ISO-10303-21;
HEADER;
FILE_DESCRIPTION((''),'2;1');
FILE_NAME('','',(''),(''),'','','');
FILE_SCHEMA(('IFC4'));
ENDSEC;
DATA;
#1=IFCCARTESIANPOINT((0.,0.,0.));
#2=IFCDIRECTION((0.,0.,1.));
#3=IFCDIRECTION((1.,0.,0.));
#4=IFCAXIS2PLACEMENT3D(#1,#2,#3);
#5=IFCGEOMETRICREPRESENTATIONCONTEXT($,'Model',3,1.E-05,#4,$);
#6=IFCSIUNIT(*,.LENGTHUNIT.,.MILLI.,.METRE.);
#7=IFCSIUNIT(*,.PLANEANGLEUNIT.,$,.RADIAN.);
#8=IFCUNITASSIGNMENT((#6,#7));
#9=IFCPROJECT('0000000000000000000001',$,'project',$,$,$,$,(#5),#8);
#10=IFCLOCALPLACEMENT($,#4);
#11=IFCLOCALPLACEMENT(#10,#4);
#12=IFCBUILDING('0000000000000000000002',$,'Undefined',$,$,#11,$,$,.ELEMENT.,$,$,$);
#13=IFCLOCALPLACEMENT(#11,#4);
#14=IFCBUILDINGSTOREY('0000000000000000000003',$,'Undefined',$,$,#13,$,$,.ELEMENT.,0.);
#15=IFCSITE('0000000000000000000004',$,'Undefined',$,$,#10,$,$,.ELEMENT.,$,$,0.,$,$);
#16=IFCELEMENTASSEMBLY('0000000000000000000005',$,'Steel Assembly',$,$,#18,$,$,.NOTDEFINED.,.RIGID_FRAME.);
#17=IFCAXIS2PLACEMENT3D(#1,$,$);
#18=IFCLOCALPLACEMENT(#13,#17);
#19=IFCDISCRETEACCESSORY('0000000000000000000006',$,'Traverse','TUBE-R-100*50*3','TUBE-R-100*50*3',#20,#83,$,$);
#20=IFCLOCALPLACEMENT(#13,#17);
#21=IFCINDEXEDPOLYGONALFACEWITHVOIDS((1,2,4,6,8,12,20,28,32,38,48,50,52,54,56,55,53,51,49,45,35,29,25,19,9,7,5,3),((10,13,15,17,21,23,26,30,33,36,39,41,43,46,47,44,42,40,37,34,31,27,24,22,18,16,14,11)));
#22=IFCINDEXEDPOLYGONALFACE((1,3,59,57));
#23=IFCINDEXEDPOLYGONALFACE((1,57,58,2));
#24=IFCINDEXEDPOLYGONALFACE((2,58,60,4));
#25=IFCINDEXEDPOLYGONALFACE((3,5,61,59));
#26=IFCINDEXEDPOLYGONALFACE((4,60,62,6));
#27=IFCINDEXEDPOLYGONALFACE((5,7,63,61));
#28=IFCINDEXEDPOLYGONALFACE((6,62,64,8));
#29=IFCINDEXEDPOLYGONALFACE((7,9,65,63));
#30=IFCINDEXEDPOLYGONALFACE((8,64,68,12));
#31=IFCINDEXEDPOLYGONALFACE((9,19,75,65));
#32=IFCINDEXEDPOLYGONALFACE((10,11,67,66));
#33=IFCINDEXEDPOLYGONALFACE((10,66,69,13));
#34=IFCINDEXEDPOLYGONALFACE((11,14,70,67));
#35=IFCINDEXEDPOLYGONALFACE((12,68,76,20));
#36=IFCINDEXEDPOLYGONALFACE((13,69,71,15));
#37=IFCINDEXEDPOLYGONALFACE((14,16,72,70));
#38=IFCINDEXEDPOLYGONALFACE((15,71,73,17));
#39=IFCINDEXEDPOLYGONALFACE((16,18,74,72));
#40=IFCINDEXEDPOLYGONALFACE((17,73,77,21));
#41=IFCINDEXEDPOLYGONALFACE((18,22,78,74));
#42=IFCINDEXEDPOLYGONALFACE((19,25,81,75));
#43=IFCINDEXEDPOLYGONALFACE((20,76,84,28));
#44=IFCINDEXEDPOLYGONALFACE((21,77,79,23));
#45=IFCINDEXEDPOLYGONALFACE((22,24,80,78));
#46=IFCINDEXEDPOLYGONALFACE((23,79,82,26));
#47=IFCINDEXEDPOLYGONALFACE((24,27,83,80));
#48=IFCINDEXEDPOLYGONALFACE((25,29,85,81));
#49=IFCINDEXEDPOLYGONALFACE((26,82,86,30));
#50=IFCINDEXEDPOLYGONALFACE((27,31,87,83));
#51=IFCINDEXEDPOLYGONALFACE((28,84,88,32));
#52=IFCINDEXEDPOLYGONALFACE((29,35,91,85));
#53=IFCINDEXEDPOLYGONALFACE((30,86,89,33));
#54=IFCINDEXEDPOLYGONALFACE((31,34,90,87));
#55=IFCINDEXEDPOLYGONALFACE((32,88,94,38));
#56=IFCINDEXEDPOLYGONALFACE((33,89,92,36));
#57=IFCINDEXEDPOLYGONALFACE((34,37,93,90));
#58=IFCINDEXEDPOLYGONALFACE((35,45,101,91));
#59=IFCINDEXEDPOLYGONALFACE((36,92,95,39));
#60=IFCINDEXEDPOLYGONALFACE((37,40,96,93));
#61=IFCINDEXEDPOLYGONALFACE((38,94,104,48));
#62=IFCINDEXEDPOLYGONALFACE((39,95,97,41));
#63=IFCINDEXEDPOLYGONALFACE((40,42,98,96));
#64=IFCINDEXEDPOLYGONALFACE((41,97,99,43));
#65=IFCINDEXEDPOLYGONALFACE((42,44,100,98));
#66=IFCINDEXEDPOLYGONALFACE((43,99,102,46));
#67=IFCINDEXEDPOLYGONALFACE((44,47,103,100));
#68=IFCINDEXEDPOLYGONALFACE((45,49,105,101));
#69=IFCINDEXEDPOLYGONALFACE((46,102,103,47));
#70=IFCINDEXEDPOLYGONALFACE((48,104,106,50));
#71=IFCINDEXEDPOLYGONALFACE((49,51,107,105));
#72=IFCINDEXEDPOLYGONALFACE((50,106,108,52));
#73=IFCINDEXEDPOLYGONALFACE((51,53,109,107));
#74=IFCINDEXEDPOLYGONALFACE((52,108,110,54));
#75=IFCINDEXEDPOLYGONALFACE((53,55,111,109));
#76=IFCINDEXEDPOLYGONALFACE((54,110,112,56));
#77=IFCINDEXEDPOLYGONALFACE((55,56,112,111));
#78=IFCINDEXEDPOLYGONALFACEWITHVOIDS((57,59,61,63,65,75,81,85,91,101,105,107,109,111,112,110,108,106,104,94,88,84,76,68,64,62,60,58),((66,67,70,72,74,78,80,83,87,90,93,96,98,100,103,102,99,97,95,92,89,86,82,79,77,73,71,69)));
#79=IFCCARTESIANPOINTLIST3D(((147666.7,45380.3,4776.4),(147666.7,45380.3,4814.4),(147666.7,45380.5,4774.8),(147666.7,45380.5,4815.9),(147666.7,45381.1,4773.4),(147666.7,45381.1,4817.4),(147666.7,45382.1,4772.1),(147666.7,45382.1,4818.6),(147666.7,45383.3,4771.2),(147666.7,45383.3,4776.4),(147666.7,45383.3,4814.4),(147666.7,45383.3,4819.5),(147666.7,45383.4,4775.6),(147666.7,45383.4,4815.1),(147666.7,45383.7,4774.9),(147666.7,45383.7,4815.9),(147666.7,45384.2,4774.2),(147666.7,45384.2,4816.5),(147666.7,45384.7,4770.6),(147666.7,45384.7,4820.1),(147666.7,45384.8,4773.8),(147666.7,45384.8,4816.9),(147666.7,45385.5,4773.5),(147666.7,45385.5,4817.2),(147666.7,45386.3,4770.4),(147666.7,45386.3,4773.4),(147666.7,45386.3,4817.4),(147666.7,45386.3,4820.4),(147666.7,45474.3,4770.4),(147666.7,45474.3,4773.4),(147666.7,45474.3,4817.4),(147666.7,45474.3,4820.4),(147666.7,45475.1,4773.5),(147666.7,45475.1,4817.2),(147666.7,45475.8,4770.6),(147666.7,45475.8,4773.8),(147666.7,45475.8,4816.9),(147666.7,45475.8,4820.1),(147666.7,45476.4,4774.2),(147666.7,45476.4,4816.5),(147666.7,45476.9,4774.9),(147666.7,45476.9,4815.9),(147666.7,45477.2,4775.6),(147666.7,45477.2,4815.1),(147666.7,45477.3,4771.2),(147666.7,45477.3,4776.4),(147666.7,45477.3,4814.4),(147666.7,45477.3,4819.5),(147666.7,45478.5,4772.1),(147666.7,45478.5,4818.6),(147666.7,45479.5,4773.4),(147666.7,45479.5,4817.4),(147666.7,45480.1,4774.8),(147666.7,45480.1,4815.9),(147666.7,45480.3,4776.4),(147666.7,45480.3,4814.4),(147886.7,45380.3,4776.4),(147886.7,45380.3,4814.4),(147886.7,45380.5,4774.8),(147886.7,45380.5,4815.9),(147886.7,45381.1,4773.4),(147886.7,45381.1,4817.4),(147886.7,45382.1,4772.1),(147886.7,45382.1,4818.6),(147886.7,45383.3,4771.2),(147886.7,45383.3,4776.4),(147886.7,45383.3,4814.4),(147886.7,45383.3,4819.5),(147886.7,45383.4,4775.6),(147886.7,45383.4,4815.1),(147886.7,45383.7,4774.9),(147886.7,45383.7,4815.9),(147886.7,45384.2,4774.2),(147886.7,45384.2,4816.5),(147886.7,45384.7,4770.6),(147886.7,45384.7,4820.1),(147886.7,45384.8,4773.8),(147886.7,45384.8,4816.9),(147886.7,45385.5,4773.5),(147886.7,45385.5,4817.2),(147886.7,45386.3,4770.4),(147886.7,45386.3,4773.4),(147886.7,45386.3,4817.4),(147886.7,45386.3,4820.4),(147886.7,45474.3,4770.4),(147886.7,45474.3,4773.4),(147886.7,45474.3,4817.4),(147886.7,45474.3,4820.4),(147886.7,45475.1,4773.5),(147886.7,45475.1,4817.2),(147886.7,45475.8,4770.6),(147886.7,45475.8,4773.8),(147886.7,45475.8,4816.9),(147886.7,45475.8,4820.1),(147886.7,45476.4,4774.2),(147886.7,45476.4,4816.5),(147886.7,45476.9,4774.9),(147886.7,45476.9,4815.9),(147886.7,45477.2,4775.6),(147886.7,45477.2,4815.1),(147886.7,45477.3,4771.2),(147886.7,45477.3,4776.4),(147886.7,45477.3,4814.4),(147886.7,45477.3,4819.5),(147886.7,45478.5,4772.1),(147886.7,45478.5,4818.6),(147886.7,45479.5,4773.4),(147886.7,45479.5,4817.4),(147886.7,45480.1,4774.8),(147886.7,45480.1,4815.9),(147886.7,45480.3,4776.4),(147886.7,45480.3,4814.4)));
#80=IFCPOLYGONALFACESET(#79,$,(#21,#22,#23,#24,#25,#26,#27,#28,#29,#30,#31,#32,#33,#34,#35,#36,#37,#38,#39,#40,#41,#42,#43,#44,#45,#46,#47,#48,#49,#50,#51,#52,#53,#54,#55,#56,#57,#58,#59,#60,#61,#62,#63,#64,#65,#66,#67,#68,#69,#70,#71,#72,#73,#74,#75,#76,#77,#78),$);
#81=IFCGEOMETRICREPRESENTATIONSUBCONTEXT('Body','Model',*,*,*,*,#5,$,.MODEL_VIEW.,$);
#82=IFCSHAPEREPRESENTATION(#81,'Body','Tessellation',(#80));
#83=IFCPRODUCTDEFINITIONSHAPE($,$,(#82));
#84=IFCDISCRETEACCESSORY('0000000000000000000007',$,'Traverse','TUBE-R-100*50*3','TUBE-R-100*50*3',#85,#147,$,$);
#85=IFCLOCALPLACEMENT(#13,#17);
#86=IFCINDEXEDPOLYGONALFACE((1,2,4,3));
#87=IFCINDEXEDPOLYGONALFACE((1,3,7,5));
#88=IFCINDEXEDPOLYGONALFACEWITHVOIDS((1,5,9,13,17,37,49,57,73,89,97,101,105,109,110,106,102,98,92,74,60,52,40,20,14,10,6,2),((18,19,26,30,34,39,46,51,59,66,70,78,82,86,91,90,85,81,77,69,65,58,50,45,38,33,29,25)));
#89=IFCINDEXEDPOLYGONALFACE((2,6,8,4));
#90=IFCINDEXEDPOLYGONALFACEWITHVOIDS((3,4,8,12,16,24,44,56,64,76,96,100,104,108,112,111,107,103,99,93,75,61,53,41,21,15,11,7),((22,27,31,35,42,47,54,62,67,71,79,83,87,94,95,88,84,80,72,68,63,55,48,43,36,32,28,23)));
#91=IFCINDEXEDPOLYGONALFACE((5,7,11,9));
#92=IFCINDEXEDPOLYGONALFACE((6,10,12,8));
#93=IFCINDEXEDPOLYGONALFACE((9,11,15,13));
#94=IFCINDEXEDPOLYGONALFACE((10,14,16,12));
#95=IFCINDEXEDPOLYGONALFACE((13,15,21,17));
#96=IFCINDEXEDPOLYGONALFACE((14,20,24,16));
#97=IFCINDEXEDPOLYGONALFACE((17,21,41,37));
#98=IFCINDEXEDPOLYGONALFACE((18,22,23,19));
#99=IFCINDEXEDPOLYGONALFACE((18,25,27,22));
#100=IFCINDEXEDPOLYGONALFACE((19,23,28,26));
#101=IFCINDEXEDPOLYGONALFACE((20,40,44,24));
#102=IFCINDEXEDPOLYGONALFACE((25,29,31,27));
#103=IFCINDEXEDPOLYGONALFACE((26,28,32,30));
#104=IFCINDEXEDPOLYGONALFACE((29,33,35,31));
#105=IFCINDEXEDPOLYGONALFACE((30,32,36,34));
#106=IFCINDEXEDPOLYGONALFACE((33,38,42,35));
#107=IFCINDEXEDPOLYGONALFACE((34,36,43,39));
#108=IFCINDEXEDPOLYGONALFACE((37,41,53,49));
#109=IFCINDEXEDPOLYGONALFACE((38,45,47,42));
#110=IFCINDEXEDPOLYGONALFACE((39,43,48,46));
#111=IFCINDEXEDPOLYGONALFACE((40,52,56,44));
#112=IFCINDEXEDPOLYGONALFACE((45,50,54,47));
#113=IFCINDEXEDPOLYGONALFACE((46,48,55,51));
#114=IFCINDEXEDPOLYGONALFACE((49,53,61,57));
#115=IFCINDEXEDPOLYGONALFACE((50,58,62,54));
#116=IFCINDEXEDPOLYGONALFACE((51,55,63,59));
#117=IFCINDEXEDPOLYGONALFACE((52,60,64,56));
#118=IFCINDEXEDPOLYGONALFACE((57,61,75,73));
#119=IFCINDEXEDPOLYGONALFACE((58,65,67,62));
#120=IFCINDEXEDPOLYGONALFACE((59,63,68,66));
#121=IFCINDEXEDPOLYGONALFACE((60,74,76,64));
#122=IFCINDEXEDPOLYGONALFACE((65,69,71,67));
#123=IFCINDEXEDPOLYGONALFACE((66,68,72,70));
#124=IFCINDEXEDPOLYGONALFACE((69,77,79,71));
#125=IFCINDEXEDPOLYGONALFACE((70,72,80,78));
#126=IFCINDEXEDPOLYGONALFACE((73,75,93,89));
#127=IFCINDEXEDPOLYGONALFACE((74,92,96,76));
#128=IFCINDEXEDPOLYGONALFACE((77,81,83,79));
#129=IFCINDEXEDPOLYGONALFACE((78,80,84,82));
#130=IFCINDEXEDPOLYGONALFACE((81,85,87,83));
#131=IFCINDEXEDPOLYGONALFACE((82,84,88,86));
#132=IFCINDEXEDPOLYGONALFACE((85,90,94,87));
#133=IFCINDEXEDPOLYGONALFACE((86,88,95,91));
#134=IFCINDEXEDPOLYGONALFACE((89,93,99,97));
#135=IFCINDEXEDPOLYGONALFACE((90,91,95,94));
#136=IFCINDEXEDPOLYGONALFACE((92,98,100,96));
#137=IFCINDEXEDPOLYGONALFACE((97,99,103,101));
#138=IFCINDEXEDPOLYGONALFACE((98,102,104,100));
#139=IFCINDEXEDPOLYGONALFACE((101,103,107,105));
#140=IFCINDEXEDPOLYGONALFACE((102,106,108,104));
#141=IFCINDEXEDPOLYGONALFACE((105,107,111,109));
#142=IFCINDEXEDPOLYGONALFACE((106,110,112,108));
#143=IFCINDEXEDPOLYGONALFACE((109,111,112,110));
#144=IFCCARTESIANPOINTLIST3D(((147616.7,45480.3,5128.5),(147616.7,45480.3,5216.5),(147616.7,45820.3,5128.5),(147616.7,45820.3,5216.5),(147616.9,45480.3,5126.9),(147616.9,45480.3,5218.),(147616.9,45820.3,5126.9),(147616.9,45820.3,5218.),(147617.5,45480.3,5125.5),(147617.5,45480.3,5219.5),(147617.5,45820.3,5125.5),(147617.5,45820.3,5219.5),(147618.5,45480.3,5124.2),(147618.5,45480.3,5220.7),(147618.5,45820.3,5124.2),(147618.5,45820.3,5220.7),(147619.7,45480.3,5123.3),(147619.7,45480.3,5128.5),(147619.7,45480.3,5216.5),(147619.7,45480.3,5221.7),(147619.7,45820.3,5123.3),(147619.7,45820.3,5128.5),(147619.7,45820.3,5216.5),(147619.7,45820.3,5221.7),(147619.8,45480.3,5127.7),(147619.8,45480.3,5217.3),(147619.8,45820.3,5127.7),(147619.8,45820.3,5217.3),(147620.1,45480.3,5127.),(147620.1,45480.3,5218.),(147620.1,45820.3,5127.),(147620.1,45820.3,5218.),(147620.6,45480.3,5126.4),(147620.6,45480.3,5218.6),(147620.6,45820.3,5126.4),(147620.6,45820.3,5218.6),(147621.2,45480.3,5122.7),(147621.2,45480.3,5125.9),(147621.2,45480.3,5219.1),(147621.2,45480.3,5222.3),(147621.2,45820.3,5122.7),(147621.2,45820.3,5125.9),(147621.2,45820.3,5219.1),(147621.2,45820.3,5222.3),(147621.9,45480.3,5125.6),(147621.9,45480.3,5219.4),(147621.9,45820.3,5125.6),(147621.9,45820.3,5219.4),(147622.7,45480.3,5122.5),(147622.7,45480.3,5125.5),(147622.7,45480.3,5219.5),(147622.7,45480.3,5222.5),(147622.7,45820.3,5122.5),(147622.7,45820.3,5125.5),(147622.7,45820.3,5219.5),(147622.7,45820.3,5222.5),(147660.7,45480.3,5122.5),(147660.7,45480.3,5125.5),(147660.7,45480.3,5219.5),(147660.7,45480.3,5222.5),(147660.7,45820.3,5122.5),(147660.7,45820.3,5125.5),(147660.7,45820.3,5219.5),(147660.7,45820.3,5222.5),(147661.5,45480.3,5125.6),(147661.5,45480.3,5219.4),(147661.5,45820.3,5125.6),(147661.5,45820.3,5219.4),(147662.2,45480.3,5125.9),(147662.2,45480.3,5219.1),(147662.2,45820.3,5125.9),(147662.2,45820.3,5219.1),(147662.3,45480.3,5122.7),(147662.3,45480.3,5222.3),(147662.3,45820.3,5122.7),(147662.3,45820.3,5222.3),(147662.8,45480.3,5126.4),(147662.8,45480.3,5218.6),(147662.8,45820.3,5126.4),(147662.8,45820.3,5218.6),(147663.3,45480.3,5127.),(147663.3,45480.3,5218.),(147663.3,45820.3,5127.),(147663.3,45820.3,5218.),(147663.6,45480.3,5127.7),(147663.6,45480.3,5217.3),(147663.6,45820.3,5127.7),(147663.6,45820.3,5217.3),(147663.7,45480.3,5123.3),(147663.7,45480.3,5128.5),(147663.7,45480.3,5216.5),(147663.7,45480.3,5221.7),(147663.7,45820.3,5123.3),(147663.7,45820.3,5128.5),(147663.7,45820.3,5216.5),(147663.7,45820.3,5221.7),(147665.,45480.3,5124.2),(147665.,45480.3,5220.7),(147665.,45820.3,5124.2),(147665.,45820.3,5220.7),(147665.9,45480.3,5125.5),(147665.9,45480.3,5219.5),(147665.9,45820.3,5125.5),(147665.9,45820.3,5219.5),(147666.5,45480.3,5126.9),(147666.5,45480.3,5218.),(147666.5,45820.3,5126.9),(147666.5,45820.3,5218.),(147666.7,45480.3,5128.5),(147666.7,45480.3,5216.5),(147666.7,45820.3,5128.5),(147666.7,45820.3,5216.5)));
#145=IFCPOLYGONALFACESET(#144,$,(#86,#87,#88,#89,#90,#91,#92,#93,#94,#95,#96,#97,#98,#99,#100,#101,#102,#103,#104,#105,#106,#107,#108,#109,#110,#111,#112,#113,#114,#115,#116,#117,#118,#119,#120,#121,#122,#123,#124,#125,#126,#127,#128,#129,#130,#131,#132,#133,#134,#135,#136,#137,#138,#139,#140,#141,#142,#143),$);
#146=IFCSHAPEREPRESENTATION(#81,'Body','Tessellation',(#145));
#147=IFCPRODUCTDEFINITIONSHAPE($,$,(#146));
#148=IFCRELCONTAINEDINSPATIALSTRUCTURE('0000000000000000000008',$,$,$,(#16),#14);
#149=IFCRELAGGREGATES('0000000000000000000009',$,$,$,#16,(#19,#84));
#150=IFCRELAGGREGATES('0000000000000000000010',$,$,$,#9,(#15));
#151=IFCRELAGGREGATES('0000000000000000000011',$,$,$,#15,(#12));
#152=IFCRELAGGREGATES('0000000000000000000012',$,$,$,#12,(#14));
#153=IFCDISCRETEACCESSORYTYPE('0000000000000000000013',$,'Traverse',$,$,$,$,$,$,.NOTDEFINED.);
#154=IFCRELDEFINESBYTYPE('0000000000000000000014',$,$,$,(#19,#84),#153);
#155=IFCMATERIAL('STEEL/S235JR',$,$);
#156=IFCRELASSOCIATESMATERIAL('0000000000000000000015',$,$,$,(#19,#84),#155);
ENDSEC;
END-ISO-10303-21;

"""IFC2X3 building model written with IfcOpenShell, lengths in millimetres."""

from ifc_helpers import new_model, si_unit, frame, origin_with_axes, origin_2d_with_axis, place, context, subcontext, project, spatial, hollow_rectangle, extrude, material, type_object, element, aggregate, save


model = new_model("IFC2X3")

# Units and contexts
model_context = context("Model", 3, precision=1e-05, world=origin_with_axes())
body_context = subcontext(model_context, "Body", "Model", "MODEL_VIEW")
ifc_project = project(units=[si_unit("LENGTHUNIT", "METRE", prefix="MILLI"), si_unit("PLANEANGLEUNIT", "RADIAN")], contexts=[model_context])

# Site, building, storey
site_placement = place(None, origin_with_axes())
site = spatial("IfcSite", under=ifc_project, at=site_placement, Name="Undefined", CompositionType="ELEMENT", RefElevation=0.0)
building_placement = place(site_placement, origin_with_axes())
building = spatial("IfcBuilding", under=site, at=building_placement, Name="Undefined", CompositionType="ELEMENT")
storey_placement = place(building_placement, origin_with_axes())
storey = spatial("IfcBuildingStorey", under=building, at=storey_placement, Name="Undefined", CompositionType="ELEMENT", Elevation=0.0)

# Element assembly
ifc_material_1 = material(Name="STEEL/S235JR")
assembly_1_placement = place(storey_placement, origin_with_axes())
assembly_1 = element("IfcElementAssembly", 1, at=assembly_1_placement, inside=storey, Name="Steel Assembly", AssemblyPlace="NOTDEFINED", PredefinedType="RIGID_FRAME")

# Discrete accessories
discrete_accessory_type_1 = type_object("IfcDiscreteAccessoryType", Name="Traverse")
discrete_accessory_1_placement = place(assembly_1_placement, frame((147886.7, 45430.3, 4795.4), z_axis=(0.0, 1.0, 0.0), x_axis=(-1.0, 0.0, 0.0)))
discrete_accessory_1 = element("IfcDiscreteAccessory", 2, at=discrete_accessory_1_placement, type_object=discrete_accessory_type_1, material=ifc_material_1, Name="Traverse", Description="TUBE-R-100*50*3", ObjectType="TUBE-R-100*50*3", context=body_context, shape_type="SweptSolid", body=[
    extrude(hollow_rectangle(XDim=50.0, YDim=100.0, WallThickness=3.0, InnerFilletRadius=3.0, OuterFilletRadius=6.0, at=origin_2d_with_axis()), frame((220.0, 0.0, 0.0), z_axis=(-1.0, 0.0, 0.0), x_axis=(0.0, -1.0, 0.0)), (0.0, 0.0, 1.0), 220.0),
])
discrete_accessory_2_placement = place(assembly_1_placement, frame((147641.7, 45480.3, 5172.5), z_axis=(0.0, 0.0, 1.0), x_axis=(0.0, 1.0, 0.0)))
discrete_accessory_2 = element("IfcDiscreteAccessory", 3, at=discrete_accessory_2_placement, type_object=discrete_accessory_type_1, material=ifc_material_1, Name="Traverse", Description="TUBE-R-100*50*3", ObjectType="TUBE-R-100*50*3", context=body_context, shape_type="SweptSolid", body=[
    extrude(hollow_rectangle(XDim=50.0, YDim=100.0, WallThickness=3.0, InnerFilletRadius=3.0, OuterFilletRadius=6.0, at=origin_2d_with_axis()), frame((340.0, 0.0, 0.0), z_axis=(-1.0, 0.0, 0.0), x_axis=(0.0, -1.0, 0.0)), (0.0, 0.0, 1.0), 340.0),
])

aggregate(assembly_1, [discrete_accessory_1, discrete_accessory_2])

save(model, "model.ifc")
